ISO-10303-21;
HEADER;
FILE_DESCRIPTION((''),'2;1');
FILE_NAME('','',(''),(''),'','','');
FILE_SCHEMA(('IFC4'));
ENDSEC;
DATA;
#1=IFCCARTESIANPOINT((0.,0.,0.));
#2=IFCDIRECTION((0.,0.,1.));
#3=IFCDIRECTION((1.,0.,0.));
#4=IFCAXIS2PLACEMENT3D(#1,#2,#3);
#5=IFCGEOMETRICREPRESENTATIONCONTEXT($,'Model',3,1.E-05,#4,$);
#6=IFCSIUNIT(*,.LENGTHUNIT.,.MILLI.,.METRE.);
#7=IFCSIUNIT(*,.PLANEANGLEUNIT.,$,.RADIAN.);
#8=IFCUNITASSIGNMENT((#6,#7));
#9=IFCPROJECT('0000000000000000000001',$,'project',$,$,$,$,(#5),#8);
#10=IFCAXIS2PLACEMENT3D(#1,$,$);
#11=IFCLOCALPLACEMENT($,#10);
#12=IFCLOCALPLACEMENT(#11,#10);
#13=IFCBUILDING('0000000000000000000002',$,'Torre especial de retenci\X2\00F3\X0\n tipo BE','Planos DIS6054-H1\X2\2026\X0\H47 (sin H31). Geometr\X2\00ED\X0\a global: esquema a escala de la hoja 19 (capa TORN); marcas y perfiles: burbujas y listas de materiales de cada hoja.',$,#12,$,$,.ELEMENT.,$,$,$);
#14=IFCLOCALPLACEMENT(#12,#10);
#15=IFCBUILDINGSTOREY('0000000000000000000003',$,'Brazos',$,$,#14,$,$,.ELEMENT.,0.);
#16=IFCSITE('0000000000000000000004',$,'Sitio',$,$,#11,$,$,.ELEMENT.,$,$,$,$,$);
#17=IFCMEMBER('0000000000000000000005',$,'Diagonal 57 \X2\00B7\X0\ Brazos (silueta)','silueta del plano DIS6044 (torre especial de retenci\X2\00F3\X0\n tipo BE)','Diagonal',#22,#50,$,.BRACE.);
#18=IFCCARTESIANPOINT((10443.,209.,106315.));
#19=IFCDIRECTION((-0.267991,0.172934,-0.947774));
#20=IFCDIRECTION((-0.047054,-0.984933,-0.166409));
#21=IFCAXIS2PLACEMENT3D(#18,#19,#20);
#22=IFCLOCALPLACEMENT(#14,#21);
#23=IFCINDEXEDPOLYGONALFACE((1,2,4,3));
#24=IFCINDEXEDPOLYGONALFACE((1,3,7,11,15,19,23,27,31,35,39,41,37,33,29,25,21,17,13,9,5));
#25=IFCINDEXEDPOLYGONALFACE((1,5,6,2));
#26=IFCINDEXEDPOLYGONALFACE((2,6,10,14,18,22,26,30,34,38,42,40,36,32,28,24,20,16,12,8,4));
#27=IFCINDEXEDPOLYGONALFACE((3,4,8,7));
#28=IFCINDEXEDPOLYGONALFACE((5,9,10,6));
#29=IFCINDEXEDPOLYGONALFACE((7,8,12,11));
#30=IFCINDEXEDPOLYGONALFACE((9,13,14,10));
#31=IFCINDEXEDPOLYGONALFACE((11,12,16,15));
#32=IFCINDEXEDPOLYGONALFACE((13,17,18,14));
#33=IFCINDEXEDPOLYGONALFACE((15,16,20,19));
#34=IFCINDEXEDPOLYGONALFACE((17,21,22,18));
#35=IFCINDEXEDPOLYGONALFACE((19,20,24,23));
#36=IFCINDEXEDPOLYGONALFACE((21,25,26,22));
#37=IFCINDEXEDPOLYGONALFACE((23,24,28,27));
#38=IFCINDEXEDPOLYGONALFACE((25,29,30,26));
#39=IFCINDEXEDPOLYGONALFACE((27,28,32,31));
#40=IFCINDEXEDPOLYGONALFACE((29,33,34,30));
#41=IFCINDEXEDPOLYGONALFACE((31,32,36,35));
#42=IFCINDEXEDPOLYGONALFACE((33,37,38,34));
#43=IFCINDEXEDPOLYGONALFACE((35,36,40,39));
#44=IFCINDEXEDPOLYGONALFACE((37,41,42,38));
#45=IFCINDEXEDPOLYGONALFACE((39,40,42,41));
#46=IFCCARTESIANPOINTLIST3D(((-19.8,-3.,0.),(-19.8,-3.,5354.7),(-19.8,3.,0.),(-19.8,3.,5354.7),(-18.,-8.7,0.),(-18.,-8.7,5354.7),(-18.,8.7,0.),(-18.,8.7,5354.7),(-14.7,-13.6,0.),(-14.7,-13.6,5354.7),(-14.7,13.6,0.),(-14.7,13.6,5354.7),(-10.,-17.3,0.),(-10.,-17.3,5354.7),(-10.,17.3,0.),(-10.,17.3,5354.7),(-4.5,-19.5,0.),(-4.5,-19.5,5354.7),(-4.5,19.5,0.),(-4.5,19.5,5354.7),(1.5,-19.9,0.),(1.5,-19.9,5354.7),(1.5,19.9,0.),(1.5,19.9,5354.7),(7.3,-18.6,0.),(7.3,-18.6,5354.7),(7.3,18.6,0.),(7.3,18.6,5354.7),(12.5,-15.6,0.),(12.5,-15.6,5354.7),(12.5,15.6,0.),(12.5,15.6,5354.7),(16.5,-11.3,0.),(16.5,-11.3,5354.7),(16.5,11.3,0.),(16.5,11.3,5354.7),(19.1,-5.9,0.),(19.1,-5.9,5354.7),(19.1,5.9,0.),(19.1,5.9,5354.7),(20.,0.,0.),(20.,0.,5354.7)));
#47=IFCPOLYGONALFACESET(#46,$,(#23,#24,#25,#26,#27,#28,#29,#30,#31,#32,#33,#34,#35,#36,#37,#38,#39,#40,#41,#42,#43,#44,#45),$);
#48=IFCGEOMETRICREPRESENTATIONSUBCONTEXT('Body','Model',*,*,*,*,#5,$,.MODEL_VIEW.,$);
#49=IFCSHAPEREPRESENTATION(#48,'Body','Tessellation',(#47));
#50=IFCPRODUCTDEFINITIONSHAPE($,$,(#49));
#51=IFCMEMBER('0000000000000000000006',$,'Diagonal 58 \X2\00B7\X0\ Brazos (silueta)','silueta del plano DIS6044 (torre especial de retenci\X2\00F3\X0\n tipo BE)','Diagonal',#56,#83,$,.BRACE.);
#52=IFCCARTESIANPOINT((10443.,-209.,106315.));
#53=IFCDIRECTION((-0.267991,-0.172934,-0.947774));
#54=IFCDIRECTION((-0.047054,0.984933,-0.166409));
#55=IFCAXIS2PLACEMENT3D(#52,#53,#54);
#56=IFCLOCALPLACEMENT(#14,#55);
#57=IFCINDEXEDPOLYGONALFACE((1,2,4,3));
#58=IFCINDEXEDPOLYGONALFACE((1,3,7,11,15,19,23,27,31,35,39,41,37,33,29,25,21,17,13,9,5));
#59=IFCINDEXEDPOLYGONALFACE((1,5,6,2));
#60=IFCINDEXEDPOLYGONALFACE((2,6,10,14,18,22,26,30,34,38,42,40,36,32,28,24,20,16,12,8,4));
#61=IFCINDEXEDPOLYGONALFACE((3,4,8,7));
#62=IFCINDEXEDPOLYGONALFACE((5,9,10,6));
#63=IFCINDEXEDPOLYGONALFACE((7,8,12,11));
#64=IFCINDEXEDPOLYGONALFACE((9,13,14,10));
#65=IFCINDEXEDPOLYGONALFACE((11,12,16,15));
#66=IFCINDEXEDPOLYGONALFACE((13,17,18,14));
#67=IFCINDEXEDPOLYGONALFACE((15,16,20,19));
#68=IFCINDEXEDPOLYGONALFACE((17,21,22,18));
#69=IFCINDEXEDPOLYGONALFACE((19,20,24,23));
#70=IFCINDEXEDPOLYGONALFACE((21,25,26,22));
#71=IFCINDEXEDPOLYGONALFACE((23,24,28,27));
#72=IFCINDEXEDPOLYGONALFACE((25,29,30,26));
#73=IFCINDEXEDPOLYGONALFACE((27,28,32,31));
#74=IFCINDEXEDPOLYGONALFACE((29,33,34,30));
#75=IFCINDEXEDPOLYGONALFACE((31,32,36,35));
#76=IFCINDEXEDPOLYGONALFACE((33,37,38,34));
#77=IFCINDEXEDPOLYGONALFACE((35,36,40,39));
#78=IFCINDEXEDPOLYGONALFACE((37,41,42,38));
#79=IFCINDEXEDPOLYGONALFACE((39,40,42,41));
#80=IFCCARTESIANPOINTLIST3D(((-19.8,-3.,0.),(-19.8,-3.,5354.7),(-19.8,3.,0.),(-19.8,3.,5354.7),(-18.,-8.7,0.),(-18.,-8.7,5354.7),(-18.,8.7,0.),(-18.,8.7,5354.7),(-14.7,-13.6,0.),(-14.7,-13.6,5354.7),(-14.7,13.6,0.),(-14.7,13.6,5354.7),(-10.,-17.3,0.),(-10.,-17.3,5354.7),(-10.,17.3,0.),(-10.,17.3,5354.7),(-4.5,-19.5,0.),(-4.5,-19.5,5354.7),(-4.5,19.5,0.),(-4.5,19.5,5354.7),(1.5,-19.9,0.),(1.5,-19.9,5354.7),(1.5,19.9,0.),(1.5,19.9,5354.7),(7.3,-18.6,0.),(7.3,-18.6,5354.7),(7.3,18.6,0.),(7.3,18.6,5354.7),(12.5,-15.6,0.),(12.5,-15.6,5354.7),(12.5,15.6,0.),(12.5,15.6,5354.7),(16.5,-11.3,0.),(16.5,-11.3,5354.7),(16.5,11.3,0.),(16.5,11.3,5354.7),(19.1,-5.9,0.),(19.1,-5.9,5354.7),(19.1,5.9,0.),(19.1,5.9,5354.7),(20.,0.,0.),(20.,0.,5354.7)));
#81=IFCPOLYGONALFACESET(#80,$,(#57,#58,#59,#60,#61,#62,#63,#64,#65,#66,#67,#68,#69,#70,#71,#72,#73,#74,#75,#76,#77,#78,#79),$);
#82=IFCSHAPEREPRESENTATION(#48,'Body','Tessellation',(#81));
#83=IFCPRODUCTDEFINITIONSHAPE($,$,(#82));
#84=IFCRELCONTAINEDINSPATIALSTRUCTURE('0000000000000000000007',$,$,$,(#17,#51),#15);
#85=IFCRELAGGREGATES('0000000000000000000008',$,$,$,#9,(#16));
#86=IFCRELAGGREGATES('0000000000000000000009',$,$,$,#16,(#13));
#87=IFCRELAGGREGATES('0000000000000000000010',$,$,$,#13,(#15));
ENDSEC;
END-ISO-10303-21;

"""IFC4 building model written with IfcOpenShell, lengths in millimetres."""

from ifc_helpers import new_model, si_unit, frame, origin, origin_with_axes, place, context, subcontext, project, spatial, circle, extrude, element, save


model = new_model("IFC4")

# Units and contexts
model_context = context("Model", 3, precision=1e-05, world=origin_with_axes())
body_context = subcontext(model_context, "Body", "Model", "MODEL_VIEW")
ifc_project = project(units=[si_unit("LENGTHUNIT", "METRE", prefix="MILLI"), si_unit("PLANEANGLEUNIT", "RADIAN")], contexts=[model_context])

# Site, building, storey
site_placement = place(None, origin())
site = spatial("IfcSite", under=ifc_project, at=site_placement, Name="Sitio", CompositionType="ELEMENT")
building_placement = place(site_placement, origin())
building = spatial("IfcBuilding", under=site, at=building_placement, Name="Torre especial de retención tipo BE", Description="Planos DIS6054-H1…H47 (sin H31). Geometría global: esquema a escala de la hoja 19 (capa TORN); marcas y perfiles: burbujas y listas de materiales de cada hoja.", CompositionType="ELEMENT")
storey_placement = place(building_placement, origin())
storey = spatial("IfcBuildingStorey", under=building, at=storey_placement, Name="Brazos", CompositionType="ELEMENT", Elevation=0.0)

# Members
for number, where, z_axis, x_axis, name in (
    (1, (10443.0, 209.0, 106315.0), (-0.267991, 0.172934, -0.947774), (-0.047054, -0.984933, -0.166409), "Diagonal 57 · Brazos (silueta)"),
    (2, (10443.0, -209.0, 106315.0), (-0.267991, -0.172934, -0.947774), (-0.047054, 0.984933, -0.166409), "Diagonal 58 · Brazos (silueta)"),
):
    element("IfcMember", number, at=place(storey_placement, frame(where, z_axis=z_axis, x_axis=x_axis)), inside=storey, Name=name, Description="silueta del plano DIS6044 (torre especial de retención tipo BE)", ObjectType="Diagonal", PredefinedType="BRACE", context=body_context, shape_type="SweptSolid", body=[
        extrude(circle(Radius=20.0), None, (0.0, 0.0, 1.0), 5354.7),
    ])

save(model, "model.ifc")
